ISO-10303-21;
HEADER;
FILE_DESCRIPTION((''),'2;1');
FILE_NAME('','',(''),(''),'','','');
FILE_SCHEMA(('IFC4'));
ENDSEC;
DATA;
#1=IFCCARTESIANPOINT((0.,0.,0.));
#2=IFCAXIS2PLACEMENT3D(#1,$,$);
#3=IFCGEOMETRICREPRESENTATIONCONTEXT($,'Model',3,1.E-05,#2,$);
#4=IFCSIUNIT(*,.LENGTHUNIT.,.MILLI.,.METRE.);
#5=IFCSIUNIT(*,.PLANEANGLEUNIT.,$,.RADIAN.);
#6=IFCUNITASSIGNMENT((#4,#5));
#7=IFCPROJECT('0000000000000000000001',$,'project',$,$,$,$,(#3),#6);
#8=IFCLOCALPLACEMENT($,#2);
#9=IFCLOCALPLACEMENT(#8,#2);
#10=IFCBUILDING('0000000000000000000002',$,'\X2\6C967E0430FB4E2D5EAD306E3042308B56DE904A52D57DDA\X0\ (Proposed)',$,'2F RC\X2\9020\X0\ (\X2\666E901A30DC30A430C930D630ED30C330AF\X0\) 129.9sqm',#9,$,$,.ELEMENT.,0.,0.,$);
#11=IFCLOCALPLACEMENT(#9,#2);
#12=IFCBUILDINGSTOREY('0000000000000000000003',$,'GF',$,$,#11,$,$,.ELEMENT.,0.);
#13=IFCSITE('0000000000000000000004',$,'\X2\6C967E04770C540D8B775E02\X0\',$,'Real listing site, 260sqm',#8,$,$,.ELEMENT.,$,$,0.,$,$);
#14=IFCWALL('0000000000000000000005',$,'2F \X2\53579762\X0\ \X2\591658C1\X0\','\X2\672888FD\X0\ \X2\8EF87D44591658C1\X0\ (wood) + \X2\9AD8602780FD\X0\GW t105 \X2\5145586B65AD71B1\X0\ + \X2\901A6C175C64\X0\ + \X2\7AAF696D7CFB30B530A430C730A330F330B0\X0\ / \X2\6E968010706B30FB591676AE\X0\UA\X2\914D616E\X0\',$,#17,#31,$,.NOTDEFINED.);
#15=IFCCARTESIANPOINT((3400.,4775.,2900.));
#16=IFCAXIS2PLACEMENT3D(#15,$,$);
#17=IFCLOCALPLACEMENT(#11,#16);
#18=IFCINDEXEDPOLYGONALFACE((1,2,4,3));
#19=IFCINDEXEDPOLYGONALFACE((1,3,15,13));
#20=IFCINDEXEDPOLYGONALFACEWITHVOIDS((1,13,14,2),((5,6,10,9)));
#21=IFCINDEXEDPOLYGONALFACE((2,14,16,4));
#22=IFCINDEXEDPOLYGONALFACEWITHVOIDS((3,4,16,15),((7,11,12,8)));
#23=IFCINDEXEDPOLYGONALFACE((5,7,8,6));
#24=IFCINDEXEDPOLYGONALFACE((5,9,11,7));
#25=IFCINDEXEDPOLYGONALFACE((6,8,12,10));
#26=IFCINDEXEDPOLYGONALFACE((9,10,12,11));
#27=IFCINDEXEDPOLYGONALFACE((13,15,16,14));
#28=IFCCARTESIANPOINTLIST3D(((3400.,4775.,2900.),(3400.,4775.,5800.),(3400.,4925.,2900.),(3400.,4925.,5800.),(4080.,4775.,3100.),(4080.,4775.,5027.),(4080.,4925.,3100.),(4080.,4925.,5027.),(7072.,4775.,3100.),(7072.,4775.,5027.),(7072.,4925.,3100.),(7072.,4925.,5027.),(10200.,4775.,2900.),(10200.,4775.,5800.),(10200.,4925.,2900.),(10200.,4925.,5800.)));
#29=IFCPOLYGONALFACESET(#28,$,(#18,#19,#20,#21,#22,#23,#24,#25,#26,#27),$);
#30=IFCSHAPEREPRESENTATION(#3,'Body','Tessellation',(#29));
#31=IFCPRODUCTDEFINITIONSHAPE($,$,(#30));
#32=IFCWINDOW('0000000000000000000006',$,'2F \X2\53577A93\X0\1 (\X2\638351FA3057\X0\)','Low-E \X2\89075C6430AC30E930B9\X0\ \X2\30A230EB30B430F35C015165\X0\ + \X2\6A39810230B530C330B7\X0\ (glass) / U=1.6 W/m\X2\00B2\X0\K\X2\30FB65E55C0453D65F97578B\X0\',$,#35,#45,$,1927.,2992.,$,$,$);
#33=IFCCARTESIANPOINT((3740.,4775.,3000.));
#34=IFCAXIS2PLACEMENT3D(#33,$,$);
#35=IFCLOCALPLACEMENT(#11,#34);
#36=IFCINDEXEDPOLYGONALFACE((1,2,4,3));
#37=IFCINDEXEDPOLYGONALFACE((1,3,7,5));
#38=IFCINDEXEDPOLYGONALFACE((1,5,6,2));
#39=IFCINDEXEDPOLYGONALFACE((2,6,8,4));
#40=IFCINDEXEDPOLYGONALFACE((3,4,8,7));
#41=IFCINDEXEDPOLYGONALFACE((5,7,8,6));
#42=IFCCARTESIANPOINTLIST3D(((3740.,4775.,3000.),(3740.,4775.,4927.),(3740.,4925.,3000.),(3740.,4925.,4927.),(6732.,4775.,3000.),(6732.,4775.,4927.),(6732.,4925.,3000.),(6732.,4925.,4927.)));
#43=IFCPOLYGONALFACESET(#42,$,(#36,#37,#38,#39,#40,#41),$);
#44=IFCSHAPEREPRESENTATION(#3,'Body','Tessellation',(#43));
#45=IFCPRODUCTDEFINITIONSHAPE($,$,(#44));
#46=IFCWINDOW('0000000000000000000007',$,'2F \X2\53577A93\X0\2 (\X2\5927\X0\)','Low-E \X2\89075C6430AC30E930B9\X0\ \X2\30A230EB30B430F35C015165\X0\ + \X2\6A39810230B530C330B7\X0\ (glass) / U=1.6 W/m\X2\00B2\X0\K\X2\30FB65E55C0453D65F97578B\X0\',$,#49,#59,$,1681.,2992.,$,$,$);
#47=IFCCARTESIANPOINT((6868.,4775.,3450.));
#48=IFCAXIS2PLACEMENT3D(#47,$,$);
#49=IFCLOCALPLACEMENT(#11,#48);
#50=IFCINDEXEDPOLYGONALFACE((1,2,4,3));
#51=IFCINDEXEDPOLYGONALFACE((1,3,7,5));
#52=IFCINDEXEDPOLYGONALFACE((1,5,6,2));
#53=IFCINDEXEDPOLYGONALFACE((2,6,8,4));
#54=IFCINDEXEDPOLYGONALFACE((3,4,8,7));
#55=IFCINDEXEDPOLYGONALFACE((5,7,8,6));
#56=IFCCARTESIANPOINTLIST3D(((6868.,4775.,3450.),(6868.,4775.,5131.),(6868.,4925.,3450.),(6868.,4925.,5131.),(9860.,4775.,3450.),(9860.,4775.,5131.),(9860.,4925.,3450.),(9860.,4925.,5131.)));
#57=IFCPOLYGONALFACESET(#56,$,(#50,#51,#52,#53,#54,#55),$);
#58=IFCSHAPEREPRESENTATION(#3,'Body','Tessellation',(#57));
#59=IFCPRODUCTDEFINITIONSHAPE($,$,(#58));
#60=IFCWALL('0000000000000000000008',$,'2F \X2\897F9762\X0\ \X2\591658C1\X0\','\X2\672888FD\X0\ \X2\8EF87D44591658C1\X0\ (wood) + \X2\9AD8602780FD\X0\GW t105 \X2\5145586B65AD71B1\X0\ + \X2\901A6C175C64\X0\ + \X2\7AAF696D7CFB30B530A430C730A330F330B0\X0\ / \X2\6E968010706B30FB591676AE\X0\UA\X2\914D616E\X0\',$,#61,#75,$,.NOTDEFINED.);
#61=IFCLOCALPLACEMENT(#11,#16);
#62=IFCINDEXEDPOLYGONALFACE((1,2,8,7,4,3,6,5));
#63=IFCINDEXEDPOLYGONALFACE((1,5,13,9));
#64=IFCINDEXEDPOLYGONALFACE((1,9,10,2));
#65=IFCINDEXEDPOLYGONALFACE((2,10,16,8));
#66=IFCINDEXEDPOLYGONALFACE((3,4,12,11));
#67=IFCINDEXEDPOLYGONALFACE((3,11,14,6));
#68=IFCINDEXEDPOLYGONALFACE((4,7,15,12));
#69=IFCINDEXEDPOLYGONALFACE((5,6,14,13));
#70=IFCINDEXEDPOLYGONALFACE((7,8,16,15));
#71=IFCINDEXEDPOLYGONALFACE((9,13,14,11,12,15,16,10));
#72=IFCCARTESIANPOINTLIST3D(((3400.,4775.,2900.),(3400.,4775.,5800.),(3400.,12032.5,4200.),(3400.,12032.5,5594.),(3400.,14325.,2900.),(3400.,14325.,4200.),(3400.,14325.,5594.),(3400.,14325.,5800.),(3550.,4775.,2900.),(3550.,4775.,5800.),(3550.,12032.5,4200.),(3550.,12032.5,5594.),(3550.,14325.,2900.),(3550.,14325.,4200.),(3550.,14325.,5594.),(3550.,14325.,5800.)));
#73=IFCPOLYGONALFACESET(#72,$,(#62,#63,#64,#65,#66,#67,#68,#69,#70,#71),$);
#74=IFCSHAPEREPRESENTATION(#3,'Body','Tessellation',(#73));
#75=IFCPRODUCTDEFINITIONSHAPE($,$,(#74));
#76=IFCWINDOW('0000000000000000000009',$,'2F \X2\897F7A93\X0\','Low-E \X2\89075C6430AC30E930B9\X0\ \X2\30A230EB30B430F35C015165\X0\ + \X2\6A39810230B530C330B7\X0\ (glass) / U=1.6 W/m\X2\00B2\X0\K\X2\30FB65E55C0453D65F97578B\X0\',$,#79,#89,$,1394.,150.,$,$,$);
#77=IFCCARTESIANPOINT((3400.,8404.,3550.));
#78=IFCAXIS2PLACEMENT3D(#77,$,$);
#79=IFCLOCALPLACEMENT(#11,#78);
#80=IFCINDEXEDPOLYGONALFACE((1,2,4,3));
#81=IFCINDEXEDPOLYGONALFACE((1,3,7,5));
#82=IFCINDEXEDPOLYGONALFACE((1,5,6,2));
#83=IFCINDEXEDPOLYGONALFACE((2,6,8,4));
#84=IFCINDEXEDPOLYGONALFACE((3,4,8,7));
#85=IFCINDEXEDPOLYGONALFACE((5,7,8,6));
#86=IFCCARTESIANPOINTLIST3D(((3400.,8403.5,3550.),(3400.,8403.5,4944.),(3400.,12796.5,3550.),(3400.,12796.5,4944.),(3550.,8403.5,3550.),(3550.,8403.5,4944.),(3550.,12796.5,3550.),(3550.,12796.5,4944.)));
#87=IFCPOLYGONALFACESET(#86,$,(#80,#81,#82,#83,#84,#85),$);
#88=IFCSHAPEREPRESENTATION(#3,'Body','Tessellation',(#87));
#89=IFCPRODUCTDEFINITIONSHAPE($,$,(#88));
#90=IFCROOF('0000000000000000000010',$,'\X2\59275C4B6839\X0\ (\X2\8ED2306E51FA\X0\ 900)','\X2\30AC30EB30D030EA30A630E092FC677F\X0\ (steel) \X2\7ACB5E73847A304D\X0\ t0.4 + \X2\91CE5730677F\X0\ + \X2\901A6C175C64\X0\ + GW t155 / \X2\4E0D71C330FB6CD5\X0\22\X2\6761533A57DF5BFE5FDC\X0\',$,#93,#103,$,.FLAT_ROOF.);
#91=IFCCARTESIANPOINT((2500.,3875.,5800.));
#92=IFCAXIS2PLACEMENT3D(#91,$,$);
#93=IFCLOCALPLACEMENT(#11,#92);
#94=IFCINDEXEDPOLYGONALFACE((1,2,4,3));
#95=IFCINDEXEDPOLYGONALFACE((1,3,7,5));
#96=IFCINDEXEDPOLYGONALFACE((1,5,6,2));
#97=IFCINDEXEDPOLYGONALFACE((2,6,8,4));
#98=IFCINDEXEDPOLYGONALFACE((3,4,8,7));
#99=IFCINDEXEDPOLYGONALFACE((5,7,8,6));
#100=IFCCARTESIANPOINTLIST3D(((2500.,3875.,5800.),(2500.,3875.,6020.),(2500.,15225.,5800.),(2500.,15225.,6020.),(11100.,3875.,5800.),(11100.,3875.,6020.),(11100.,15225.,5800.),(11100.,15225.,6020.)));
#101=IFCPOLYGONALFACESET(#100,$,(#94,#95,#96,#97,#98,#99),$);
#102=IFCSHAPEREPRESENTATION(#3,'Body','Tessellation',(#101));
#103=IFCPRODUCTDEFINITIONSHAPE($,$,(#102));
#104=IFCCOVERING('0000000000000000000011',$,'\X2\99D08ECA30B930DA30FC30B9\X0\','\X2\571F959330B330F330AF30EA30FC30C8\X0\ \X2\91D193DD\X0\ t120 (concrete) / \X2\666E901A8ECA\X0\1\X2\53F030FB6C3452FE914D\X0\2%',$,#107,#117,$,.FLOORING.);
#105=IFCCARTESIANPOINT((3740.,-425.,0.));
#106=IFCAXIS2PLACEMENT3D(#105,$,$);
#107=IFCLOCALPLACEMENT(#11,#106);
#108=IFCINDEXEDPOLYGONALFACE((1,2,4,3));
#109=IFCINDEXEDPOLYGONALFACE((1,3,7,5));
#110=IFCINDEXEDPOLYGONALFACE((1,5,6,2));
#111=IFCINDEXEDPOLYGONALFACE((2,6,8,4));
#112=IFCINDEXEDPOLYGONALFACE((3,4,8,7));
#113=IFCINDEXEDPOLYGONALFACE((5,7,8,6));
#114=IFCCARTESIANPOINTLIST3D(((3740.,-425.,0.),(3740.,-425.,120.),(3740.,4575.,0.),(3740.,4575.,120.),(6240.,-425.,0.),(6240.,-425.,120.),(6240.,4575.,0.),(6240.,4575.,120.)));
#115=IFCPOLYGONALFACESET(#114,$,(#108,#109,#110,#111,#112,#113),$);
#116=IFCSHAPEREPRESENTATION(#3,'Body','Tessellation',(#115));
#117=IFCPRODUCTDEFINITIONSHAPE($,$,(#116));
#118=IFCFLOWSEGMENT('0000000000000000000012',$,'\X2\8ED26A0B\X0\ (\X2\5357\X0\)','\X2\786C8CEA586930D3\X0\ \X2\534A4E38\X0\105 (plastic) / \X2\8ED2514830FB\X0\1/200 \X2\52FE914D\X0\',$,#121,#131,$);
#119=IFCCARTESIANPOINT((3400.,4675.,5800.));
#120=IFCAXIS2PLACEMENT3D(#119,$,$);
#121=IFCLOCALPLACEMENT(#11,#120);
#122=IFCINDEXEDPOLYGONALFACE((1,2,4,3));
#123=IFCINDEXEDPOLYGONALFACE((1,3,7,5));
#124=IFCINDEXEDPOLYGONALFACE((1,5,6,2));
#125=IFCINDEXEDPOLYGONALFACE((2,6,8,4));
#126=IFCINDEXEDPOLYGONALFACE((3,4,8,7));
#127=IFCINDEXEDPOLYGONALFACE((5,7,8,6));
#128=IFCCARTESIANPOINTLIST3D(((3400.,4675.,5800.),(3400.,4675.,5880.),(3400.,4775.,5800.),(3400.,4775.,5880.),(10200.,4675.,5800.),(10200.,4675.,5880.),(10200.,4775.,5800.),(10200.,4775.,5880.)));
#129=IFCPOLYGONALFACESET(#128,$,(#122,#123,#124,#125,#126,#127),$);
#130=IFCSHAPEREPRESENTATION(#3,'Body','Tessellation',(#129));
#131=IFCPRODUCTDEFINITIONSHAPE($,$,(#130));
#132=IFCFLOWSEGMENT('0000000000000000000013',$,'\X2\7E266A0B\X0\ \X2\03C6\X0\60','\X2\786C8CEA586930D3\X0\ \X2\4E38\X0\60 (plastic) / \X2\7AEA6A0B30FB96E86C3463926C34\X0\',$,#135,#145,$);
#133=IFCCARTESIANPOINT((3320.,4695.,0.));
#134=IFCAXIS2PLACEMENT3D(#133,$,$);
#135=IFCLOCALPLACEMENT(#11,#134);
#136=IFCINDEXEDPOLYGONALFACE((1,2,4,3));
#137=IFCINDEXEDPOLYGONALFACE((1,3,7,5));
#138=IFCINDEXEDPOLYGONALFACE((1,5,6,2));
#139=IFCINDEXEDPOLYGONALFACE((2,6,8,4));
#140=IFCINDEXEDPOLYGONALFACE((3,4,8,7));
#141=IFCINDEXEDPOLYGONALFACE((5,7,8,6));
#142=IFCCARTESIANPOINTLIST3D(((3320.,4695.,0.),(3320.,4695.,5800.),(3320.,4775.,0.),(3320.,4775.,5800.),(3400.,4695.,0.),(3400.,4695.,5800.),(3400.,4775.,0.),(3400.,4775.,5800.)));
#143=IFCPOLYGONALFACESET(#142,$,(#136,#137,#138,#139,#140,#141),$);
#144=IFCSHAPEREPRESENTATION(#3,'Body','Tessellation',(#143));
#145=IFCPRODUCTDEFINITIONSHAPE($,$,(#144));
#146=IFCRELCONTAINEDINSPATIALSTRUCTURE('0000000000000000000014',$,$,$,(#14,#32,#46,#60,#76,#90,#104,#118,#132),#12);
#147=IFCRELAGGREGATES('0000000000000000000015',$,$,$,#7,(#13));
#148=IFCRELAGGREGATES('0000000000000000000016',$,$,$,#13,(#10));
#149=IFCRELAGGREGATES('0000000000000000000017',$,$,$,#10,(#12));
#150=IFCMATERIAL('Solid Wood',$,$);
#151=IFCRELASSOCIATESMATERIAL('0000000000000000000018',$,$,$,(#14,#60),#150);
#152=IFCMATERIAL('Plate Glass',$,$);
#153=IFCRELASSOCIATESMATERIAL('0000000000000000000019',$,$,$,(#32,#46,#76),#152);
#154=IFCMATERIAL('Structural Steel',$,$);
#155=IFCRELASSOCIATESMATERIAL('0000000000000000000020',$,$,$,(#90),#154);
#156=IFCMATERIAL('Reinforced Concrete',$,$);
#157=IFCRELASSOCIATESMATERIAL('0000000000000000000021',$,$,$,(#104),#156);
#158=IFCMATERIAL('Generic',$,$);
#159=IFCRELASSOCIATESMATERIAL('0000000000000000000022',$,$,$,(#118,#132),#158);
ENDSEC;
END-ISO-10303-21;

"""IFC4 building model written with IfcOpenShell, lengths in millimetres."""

from ifc_helpers import new_model, si_unit, frame, frame_2d, origin, place, context, project, spatial, rectangle, extrude, material, element, fill, save


model = new_model("IFC4")

# Units and contexts
model_context = context("Model", 3, precision=1e-05, world=origin())
ifc_project = project(units=[si_unit("LENGTHUNIT", "METRE", prefix="MILLI"), si_unit("PLANEANGLEUNIT", "RADIAN")], contexts=[model_context])

# Site, building, storey
site_placement = place(None, origin())
site = spatial("IfcSite", under=ifc_project, at=site_placement, Name="沖縄県名護市", ObjectType="Real listing site, 260sqm", CompositionType="ELEMENT", RefElevation=0.0)
building_placement = place(site_placement, origin())
building = spatial("IfcBuilding", under=site, at=building_placement, Name="沖縄・中庭のある回遊動線 (Proposed)", ObjectType="2F RC造 (普通ボイドブロック) 129.9sqm", CompositionType="ELEMENT", ElevationOfRefHeight=0.0, ElevationOfTerrain=0.0)
storey_placement = place(building_placement, origin())
storey = spatial("IfcBuildingStorey", under=building, at=storey_placement, Name="GF", CompositionType="ELEMENT", Elevation=0.0)

# Shared definitions
ifc_material_1 = material(Name="Solid Wood")

# Shared definitions
ifc_material_2 = material(Name="Reinforced Concrete")

# Shared definitions
ifc_material_3 = material(Name="Plate Glass")

# Wall, openings, windows
wall_1_placement = place(storey_placement, frame((3400.0, 4775.0, 2900.0)))
wall_1 = element("IfcWall", 1, at=wall_1_placement, inside=storey, material=ifc_material_1, Name="2F 南面 外壁", Description="木製 軸組外壁 (wood) + 高性能GW t105 充填断熱 + 通気層 + 窯業系サイディング / 準耐火・外皮UA配慮", PredefinedType="NOTDEFINED", context=model_context, shape_type="SweptSolid", body=[
    extrude(rectangle(XDim=6800.0, YDim=150.0, at=frame_2d((3400.0, 75.0))), frame((3400.0, 4775.0, 2900.0)), (0.0, 0.0, 1.0), 2900.0),
])
opening_1_placement = place(storey_placement, frame((3740.0, 4775.0, 3000.0)))
opening_1 = element("IfcOpeningElement", 2, at=opening_1_placement, cuts=wall_1, PredefinedType="NOTDEFINED", context=model_context, shape_type="SweptSolid", body=[
    extrude(rectangle(XDim=2992.0, YDim=150.0, at=frame_2d((1496.0, 75.0))), frame((3740.0, 4775.0, 3000.0)), (0.0, 0.0, 1.0), 1927.0),
])
opening_2_placement = place(storey_placement, frame((6868.0, 4775.0, 3450.0)))
opening_2 = element("IfcOpeningElement", 3, at=opening_2_placement, cuts=wall_1, PredefinedType="NOTDEFINED", context=model_context, shape_type="SweptSolid", body=[
    extrude(rectangle(XDim=2992.0, YDim=150.0, at=frame_2d((1496.0, 75.0))), frame((6868.0, 4775.0, 3450.0)), (0.0, 0.0, 1.0), 1681.0),
])
window_1_placement = place(storey_placement, frame((3740.0, 4775.0, 3000.0)))
window_1 = element("IfcWindow", 4, at=window_1_placement, inside=storey, material=ifc_material_3, Name="2F 南窓1 (掃出し)", Description="Low-E 複層ガラス アルゴン封入 + 樹脂サッシ (glass) / U=1.6 W/m²K・日射取得型", OverallHeight=1927.0, OverallWidth=2992.0, context=model_context, shape_type="SweptSolid", body=[
    extrude(rectangle(XDim=2992.0, YDim=150.0, at=frame_2d((1496.0, 75.0))), frame((3740.0, 4775.0, 3000.0)), (0.0, 0.0, 1.0), 1927.0),
])
fill(opening_1, window_1)
window_2_placement = place(storey_placement, frame((6868.0, 4775.0, 3450.0)))
window_2 = element("IfcWindow", 5, at=window_2_placement, inside=storey, material=ifc_material_3, Name="2F 南窓2 (大)", Description="Low-E 複層ガラス アルゴン封入 + 樹脂サッシ (glass) / U=1.6 W/m²K・日射取得型", OverallHeight=1681.0, OverallWidth=2992.0, context=model_context, shape_type="SweptSolid", body=[
    extrude(rectangle(XDim=2992.0, YDim=150.0, at=frame_2d((1496.0, 75.0))), frame((6868.0, 4775.0, 3450.0)), (0.0, 0.0, 1.0), 1681.0),
])
fill(opening_2, window_2)

# Wall, opening, window
wall_2_placement = place(storey_placement, frame((3400.0, 4775.0, 2900.0)))
wall_2 = element("IfcWall", 6, at=wall_2_placement, inside=storey, material=ifc_material_1, Name="2F 西面 外壁", Description="木製 軸組外壁 (wood) + 高性能GW t105 充填断熱 + 通気層 + 窯業系サイディング / 準耐火・外皮UA配慮", PredefinedType="NOTDEFINED", context=model_context, shape_type="SweptSolid", body=[
    extrude(rectangle(XDim=150.0, YDim=9550.0, at=frame_2d((75.0, 4775.0))), frame((3400.0, 4775.0, 2900.0)), (0.0, 0.0, 1.0), 2900.0),
])
opening_3_placement = place(storey_placement, frame((3400.0, 8404.0, 3550.0)))
opening_3 = element("IfcOpeningElement", 7, at=opening_3_placement, cuts=wall_2, PredefinedType="NOTDEFINED", context=model_context, shape_type="SweptSolid", body=[
    extrude(rectangle(XDim=150.0, YDim=4393.0, at=frame_2d((75.0, 2196.0))), frame((3400.0, 8404.0, 3550.0)), (0.0, 0.0, 1.0), 1394.0),
])
window_3_placement = place(storey_placement, frame((3400.0, 8404.0, 3550.0)))
window_3 = element("IfcWindow", 8, at=window_3_placement, inside=storey, material=ifc_material_3, Name="2F 西窓", Description="Low-E 複層ガラス アルゴン封入 + 樹脂サッシ (glass) / U=1.6 W/m²K・日射取得型", OverallHeight=1394.0, OverallWidth=150.0, context=model_context, shape_type="SweptSolid", body=[
    extrude(rectangle(XDim=150.0, YDim=4393.0, at=frame_2d((75.0, 2196.0))), frame((3400.0, 8404.0, 3550.0)), (0.0, 0.0, 1.0), 1394.0),
])
fill(opening_3, window_3)

# Roof
ifc_material_4 = material(Name="Structural Steel")
roof_placement = place(storey_placement, frame((2500.0, 3875.0, 5800.0)))
element("IfcRoof", 9, at=roof_placement, inside=storey, material=ifc_material_4, Name="大屋根 (軒の出 900)", Description="ガルバリウム鋼板 (steel) 立平葺き t0.4 + 野地板 + 通気層 + GW t155 / 不燃・法22条区域対応", PredefinedType="FLAT_ROOF", context=model_context, shape_type="SweptSolid", body=[
    extrude(rectangle(XDim=8600.0, YDim=11350.0, at=frame_2d((4300.0, 5675.0))), frame((2500.0, 3875.0, 5800.0)), (0.0, 0.0, 1.0), 220.0),
])

# Covering
covering_placement = place(storey_placement, frame((3740.0, -425.0, 0.0)))
element("IfcCovering", 10, at=covering_placement, inside=storey, material=ifc_material_2, Name="駐車スペース", Description="土間コンクリート 金鏝 t120 (concrete) / 普通車1台・水勾配2%", PredefinedType="FLOORING", context=model_context, shape_type="SweptSolid", body=[
    extrude(rectangle(XDim=2500.0, YDim=5000.0, at=frame_2d((1250.0, 2500.0))), frame((3740.0, -425.0, 0.0)), (0.0, 0.0, 1.0), 120.0),
])

# Flow segments
ifc_material_5 = material(Name="Generic")
flow_segment_1_placement = place(storey_placement, frame((3400.0, 4675.0, 5800.0)))
element("IfcFlowSegment", 11, at=flow_segment_1_placement, inside=storey, material=ifc_material_5, Name="軒樋 (南)", Description="硬質塩ビ 半丸105 (plastic) / 軒先・1/200 勾配", context=model_context, shape_type="SweptSolid", body=[
    extrude(rectangle(XDim=6800.0, YDim=100.0, at=frame_2d((3400.0, 50.0))), frame((3400.0, 4675.0, 5800.0)), (0.0, 0.0, 1.0), 80.0),
])
flow_segment_2_placement = place(storey_placement, frame((3320.0, 4695.0, 0.0)))
element("IfcFlowSegment", 12, at=flow_segment_2_placement, inside=storey, material=ifc_material_5, Name="縦樋 φ60", Description="硬質塩ビ 丸60 (plastic) / 竪樋・雨水排水", context=model_context, shape_type="SweptSolid", body=[
    extrude(rectangle(XDim=80.0, YDim=80.0, at=frame_2d((40.0, 40.0))), frame((3320.0, 4695.0, 0.0)), (0.0, 0.0, 1.0), 5800.0),
])

save(model, "model.ifc")
